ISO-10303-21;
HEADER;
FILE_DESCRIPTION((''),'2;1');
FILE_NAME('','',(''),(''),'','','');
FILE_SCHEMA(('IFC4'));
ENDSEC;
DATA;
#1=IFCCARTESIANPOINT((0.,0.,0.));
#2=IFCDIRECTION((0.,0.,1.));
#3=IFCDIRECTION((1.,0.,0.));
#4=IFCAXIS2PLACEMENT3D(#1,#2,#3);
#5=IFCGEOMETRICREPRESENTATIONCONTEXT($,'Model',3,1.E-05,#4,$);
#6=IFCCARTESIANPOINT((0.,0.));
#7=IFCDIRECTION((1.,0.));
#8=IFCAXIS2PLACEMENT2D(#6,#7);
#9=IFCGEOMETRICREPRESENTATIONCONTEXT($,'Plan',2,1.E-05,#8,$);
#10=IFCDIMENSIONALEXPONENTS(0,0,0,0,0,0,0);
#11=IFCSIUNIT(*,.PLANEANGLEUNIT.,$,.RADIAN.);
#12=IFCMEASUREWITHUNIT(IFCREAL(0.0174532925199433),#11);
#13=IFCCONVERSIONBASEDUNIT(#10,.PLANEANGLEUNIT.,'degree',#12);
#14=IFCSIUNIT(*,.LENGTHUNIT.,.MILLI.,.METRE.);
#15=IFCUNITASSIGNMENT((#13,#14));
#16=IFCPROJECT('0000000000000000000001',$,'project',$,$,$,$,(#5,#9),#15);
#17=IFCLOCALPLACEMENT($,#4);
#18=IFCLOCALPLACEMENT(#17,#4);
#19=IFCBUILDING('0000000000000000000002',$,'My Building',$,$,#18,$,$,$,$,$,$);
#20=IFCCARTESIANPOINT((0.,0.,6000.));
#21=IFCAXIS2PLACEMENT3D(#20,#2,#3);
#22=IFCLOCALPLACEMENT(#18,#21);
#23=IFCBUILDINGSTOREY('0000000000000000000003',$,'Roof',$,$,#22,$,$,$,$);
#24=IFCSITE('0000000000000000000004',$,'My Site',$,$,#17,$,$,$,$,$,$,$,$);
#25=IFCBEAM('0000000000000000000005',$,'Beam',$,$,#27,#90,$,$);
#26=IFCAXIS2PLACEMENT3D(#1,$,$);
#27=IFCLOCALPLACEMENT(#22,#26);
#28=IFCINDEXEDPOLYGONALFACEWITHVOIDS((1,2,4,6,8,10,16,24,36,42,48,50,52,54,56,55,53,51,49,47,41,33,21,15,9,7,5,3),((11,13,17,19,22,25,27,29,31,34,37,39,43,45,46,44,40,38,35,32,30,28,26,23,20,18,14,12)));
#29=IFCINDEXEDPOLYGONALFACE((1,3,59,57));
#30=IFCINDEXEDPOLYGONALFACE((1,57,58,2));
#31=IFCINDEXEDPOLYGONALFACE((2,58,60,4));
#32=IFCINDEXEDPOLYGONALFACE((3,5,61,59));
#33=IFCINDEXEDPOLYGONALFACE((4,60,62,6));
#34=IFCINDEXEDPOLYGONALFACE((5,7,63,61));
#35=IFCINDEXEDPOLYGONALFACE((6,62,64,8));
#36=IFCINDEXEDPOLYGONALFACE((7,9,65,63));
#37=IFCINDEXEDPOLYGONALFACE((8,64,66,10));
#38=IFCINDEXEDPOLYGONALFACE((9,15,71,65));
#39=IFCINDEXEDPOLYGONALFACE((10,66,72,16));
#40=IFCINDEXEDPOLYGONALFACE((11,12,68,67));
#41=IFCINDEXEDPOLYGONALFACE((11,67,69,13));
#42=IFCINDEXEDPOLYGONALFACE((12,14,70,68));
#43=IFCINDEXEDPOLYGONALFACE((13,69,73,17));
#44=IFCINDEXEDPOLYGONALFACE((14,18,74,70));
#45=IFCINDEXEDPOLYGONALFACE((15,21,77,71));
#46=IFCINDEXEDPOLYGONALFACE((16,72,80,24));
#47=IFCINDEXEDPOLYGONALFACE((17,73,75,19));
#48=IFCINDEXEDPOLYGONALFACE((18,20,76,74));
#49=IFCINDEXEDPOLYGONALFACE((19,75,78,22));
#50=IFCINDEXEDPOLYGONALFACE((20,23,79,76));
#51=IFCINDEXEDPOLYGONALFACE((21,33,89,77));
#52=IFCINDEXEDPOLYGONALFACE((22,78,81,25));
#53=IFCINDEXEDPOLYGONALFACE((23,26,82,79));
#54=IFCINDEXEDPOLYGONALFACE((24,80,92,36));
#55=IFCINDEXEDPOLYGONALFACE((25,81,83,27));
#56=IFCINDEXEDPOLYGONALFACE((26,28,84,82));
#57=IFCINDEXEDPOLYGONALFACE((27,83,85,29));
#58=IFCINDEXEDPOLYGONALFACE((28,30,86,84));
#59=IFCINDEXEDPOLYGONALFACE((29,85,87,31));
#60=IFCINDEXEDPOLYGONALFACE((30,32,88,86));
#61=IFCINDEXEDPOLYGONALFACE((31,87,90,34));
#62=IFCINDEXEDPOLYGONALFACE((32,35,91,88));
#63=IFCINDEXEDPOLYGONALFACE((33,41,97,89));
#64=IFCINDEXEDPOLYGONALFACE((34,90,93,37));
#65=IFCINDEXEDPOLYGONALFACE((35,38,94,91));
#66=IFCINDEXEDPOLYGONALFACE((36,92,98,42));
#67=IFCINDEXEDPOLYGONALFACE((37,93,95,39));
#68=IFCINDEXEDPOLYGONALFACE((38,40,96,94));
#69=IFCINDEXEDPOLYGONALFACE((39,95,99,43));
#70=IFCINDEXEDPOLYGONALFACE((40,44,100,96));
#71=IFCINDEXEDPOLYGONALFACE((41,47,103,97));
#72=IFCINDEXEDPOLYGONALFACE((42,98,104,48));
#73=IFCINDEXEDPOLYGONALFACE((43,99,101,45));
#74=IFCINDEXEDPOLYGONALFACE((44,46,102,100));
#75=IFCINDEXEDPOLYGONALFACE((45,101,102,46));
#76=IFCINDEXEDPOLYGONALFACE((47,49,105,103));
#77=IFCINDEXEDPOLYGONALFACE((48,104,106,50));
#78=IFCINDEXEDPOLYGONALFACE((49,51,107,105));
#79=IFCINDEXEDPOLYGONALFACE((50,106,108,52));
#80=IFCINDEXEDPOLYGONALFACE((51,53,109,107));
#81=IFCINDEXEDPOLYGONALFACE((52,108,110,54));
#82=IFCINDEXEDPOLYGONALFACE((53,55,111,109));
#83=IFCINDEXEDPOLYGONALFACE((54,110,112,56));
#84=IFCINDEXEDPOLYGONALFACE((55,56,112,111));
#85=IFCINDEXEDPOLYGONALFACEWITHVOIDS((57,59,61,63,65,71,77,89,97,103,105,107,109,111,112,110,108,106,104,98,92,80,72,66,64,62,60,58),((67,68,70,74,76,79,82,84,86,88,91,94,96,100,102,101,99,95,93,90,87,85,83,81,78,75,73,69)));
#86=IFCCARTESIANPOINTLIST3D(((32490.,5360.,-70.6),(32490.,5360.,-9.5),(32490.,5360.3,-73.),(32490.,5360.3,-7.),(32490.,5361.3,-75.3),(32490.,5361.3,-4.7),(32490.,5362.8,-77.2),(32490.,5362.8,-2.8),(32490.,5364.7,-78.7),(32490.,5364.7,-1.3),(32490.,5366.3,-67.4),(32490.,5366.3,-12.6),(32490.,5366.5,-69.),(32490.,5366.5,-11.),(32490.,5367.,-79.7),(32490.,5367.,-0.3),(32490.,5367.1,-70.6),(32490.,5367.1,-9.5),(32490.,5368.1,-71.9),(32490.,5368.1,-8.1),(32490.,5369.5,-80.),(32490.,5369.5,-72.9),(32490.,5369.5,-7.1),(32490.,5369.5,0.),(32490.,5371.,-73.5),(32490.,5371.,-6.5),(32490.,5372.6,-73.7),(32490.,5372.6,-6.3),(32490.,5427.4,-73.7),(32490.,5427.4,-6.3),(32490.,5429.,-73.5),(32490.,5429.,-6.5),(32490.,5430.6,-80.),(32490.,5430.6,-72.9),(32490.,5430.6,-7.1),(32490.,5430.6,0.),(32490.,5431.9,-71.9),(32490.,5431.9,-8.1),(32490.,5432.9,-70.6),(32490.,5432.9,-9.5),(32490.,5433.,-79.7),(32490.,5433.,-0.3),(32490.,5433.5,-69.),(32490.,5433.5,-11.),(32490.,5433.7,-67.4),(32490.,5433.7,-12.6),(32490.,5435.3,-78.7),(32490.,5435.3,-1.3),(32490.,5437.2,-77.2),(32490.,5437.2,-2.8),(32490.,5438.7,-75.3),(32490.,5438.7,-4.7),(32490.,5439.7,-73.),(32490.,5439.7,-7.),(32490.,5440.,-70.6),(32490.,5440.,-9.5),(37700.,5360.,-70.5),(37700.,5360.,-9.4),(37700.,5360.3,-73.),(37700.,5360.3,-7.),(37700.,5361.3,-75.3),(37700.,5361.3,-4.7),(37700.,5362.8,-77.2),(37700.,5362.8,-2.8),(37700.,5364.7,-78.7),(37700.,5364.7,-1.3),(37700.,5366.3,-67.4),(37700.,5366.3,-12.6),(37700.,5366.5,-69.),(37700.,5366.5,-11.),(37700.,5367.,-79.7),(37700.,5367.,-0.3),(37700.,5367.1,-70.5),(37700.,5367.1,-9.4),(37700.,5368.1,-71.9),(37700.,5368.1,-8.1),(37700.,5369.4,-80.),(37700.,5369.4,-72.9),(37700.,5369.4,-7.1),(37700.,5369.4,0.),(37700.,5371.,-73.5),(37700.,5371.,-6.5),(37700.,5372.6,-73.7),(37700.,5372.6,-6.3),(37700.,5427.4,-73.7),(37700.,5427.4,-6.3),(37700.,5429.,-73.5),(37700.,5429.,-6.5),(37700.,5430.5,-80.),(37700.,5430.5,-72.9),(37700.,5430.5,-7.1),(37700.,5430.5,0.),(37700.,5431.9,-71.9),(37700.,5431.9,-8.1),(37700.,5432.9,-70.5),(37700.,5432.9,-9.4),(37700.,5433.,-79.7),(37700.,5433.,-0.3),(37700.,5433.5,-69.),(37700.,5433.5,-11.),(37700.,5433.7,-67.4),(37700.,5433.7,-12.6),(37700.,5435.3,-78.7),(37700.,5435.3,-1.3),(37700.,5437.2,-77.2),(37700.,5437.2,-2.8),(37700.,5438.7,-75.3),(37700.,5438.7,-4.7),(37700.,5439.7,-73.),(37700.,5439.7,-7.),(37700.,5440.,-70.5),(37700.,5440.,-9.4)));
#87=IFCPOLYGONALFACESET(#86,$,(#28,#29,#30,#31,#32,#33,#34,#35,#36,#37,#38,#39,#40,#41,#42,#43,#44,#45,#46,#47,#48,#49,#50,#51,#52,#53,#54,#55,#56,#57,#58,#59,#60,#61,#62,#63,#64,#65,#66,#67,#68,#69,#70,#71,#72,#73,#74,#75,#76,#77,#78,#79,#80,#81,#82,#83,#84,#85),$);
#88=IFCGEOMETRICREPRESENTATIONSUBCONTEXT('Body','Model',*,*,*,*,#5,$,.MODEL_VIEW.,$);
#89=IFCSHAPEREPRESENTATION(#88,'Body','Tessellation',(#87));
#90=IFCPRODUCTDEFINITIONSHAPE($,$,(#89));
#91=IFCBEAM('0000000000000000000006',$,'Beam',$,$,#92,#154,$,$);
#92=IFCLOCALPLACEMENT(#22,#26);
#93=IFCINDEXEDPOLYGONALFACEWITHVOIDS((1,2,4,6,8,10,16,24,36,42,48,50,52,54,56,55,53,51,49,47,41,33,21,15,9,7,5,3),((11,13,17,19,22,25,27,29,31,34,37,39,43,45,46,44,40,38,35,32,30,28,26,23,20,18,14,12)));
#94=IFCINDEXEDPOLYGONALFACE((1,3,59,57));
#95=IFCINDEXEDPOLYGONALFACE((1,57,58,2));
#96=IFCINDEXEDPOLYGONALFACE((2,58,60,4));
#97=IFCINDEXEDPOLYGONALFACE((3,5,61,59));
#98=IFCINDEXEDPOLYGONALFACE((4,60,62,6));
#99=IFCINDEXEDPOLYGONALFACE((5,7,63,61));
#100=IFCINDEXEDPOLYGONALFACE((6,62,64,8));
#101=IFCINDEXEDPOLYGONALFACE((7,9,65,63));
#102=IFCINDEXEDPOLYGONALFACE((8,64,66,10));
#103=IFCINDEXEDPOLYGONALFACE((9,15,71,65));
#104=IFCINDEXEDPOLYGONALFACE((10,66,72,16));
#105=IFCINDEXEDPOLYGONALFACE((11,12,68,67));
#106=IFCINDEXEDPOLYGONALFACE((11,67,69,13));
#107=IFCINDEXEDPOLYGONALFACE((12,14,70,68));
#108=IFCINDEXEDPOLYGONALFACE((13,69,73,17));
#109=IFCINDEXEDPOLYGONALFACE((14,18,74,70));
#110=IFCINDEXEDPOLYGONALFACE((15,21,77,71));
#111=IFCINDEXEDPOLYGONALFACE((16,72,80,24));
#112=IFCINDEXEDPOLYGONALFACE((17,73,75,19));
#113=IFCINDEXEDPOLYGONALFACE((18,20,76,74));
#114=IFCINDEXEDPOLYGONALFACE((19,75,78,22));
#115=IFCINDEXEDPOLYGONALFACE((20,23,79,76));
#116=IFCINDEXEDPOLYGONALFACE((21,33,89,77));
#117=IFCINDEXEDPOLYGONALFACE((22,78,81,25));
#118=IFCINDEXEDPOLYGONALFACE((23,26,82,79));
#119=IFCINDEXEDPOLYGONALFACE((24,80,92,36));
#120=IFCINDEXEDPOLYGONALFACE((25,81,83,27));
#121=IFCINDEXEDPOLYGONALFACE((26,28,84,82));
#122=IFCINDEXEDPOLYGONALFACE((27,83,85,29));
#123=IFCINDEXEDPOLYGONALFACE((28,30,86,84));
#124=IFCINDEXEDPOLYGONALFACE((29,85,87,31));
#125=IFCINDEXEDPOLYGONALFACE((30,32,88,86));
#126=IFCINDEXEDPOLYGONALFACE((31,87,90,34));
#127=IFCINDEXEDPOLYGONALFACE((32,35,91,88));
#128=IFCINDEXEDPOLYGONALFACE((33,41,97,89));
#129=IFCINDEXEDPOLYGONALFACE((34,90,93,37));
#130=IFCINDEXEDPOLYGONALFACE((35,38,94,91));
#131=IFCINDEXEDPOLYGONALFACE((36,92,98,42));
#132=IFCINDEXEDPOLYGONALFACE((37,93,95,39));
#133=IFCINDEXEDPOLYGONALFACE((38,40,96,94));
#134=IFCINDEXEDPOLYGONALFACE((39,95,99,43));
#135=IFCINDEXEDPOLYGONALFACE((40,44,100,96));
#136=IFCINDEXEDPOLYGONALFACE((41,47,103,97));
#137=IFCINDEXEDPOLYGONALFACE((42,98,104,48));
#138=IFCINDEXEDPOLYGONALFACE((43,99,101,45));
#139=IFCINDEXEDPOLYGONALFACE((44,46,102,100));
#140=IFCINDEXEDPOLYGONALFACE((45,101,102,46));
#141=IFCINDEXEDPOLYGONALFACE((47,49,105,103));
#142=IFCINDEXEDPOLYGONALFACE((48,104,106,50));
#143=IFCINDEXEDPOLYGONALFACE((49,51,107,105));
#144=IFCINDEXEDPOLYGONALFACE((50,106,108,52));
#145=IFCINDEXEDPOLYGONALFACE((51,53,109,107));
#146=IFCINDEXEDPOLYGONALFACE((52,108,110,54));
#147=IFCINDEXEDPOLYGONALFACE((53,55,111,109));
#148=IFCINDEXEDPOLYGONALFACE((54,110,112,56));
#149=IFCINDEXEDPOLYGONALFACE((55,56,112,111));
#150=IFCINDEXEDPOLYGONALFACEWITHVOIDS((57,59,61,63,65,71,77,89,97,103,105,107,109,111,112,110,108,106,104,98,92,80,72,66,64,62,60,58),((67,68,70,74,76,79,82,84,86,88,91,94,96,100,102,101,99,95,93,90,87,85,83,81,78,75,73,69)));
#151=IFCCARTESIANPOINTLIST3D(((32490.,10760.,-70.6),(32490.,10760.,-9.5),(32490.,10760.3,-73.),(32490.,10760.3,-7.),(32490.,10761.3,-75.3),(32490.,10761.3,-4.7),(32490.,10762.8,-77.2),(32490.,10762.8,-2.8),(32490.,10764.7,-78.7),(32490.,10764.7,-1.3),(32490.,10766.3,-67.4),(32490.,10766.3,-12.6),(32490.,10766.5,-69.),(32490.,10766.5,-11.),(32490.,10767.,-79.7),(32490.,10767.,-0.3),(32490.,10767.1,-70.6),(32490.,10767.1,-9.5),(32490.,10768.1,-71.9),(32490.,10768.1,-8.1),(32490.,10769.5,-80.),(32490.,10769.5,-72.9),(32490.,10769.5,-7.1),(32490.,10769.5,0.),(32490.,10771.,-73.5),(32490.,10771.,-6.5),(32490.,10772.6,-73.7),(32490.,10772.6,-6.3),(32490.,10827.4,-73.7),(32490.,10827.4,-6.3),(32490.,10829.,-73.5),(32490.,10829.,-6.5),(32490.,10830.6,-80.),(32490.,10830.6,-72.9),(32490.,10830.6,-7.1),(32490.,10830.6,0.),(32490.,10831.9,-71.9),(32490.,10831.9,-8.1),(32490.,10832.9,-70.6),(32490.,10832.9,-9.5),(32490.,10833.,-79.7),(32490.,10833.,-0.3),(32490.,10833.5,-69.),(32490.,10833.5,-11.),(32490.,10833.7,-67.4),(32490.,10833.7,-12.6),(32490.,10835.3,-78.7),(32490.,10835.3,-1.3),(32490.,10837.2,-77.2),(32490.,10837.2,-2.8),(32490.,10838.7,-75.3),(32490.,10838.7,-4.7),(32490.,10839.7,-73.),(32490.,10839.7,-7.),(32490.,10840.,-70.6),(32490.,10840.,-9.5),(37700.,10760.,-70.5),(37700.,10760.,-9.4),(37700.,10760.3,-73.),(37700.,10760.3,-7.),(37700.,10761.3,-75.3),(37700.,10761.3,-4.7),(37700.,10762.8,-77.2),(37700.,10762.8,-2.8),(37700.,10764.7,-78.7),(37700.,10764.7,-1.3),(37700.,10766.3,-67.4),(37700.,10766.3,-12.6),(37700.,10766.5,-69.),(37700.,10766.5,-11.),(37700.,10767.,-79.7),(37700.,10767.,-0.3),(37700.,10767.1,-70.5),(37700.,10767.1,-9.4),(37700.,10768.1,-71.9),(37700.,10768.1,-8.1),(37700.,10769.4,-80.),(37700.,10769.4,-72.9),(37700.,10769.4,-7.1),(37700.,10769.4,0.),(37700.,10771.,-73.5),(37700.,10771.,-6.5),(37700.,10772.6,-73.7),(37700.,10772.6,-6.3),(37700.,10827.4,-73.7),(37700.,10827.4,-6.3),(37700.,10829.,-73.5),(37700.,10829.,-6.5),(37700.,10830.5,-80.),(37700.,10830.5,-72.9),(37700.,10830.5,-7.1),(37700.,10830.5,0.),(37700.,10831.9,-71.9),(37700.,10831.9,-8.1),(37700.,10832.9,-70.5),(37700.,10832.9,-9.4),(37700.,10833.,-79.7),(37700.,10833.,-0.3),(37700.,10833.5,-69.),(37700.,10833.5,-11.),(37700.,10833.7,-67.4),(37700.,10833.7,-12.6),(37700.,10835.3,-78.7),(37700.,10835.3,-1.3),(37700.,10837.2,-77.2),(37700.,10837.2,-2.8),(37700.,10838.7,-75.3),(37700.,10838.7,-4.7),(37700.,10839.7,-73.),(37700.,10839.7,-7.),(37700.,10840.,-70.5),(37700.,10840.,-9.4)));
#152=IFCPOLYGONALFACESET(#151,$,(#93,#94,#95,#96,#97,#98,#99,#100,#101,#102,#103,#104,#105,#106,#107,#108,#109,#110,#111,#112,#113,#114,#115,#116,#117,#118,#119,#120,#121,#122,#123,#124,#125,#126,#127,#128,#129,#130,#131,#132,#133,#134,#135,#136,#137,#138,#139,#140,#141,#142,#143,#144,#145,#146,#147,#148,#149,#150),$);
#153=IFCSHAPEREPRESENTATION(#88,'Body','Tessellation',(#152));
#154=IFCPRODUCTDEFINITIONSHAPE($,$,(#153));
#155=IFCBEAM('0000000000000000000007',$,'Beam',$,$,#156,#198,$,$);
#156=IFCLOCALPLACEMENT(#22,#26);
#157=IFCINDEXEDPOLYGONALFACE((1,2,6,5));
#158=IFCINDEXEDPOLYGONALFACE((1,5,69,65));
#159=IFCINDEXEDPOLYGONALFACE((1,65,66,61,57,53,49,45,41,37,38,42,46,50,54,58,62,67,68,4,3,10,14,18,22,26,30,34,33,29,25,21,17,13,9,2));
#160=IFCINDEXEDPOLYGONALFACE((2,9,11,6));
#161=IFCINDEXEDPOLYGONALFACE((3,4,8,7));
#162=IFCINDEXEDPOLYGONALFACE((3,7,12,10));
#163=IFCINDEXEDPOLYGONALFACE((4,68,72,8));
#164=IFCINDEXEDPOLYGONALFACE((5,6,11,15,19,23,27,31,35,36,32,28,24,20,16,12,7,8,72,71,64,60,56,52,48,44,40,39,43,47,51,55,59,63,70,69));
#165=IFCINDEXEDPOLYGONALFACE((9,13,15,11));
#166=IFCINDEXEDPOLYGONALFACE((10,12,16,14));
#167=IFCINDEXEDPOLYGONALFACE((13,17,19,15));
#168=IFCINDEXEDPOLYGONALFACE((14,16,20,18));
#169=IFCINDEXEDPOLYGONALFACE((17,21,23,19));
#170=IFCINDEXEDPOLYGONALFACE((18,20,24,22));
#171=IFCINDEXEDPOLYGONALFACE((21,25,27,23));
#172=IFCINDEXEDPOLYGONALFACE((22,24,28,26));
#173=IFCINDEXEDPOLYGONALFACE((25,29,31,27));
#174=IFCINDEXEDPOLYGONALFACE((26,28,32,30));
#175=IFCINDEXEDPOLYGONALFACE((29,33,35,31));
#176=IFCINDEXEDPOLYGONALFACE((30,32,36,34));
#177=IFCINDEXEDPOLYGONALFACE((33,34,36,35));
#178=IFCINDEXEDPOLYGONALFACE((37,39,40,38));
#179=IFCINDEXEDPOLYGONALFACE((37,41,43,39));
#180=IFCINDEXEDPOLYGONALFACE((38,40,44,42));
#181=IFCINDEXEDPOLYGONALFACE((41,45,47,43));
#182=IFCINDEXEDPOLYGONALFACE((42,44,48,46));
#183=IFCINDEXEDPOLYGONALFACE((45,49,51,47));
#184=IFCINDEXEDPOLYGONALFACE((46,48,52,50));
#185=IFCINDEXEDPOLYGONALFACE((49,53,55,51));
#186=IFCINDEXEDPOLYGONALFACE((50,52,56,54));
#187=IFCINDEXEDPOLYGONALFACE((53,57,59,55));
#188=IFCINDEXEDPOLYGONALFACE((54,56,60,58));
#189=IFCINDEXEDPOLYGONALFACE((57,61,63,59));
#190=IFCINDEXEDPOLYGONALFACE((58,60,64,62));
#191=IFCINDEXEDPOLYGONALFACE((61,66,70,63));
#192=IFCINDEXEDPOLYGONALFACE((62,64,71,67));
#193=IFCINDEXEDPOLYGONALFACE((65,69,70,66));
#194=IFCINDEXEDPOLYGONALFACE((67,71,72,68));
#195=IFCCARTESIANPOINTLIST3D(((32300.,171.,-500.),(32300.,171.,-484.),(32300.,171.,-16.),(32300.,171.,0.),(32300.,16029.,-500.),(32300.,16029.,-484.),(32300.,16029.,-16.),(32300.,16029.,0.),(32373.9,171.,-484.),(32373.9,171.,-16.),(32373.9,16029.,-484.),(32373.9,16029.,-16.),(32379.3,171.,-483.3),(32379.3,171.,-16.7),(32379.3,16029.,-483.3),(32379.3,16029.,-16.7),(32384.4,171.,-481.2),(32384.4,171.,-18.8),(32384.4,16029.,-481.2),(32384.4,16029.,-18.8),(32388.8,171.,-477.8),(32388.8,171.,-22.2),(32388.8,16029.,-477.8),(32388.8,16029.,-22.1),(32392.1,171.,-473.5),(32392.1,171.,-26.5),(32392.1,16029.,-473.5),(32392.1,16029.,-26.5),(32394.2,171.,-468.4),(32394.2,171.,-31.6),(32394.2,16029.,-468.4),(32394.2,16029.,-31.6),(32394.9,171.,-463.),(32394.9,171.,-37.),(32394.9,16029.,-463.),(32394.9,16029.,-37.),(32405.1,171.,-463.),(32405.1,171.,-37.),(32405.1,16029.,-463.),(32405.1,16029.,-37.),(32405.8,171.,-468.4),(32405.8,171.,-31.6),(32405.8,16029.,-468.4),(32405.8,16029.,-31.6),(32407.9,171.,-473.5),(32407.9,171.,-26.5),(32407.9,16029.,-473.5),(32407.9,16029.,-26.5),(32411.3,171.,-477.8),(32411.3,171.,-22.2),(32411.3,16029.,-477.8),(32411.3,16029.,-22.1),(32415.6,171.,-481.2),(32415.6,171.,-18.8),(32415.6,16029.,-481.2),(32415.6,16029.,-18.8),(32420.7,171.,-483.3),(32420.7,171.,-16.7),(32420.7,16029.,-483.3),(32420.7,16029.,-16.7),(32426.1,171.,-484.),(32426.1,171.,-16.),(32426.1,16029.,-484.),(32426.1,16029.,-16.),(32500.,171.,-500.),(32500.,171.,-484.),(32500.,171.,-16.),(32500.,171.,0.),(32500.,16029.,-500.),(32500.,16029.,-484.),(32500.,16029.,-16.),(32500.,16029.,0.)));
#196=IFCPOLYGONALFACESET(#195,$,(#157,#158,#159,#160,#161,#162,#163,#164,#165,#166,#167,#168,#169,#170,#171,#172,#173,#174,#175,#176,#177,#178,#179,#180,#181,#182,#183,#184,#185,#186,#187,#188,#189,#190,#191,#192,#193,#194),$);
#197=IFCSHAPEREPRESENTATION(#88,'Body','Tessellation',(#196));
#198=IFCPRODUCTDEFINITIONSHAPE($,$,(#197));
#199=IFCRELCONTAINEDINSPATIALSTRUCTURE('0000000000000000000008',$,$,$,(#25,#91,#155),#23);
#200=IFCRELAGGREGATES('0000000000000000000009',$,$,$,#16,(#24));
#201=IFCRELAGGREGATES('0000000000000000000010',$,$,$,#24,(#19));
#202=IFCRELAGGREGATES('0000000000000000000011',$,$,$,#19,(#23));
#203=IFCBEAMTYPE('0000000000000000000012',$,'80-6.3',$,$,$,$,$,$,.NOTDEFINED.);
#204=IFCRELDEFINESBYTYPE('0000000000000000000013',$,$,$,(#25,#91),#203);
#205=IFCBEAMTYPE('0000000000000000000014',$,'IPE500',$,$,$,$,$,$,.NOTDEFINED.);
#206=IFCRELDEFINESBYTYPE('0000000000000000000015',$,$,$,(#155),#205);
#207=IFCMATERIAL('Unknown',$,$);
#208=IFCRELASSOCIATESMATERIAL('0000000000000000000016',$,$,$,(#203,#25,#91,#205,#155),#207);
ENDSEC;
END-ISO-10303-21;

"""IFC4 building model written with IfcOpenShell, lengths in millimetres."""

from ifc_helpers import new_model, entity, si_unit, converted_unit, frame, origin_with_axes, origin_2d_with_axis, place, context, subcontext, project, spatial, hollow_rectangle, i_section, extrude, material, material_profile, profile_set, profile_usage, type_object, element, save


model = new_model("IFC4")

# Units and contexts
model_context = context("Model", 3, precision=1e-05, world=origin_with_axes())
plan_context = context("Plan", 2, precision=1e-05, world=origin_2d_with_axis())
body_context = subcontext(model_context, "Body", "Model", "MODEL_VIEW")
ifc_project = project(units=[converted_unit("PLANEANGLEUNIT", "degree", entity("IfcReal", 0.0174532925199433), si_unit("PLANEANGLEUNIT", "RADIAN"), dimensions=[0, 0, 0, 0, 0, 0, 0]), si_unit("LENGTHUNIT", "METRE", prefix="MILLI")], contexts=[model_context, plan_context])

# Site, building, storey
site_placement = place(None, origin_with_axes())
site = spatial("IfcSite", under=ifc_project, at=site_placement, Name="My Site")
building_placement = place(site_placement, origin_with_axes())
building = spatial("IfcBuilding", under=site, at=building_placement, Name="My Building")
storey_placement = place(building_placement, frame((0.0, 0.0, 6000.0), z_axis=(0.0, 0.0, 1.0), x_axis=(1.0, 0.0, 0.0)))
storey = spatial("IfcBuildingStorey", under=building, at=storey_placement, Name="Roof")

# Beams
ifc_material = material(Name="Unknown")
ifc_material_profile_1 = material_profile(ifc_material, hollow_rectangle(XDim=80.0, YDim=80.0, WallThickness=6.3, InnerFilletRadius=6.3, OuterFilletRadius=9.4))
ifc_profile_set_1 = profile_set([ifc_material_profile_1])
beam_type_1 = type_object("IfcBeamType", Name="80-6.3", PredefinedType="NOTDEFINED", material=ifc_profile_set_1)
ifc_profile_usage_1 = profile_usage(ifc_profile_set_1, cardinal=8)
beam_1_placement = place(storey_placement, frame((32490.0, 5400.0, 0.0), z_axis=(1.0, 0.0, 0.0), x_axis=(0.0, 1.0, 0.0)))
element("IfcBeam", 1, at=beam_1_placement, inside=storey, type_object=beam_type_1, material=ifc_profile_usage_1, Name="Beam", context=body_context, shape_type="SweptSolid", body=[
    extrude(hollow_rectangle(XDim=80.0, YDim=80.0, WallThickness=6.3, InnerFilletRadius=6.3, OuterFilletRadius=9.4), frame((0.0, -40.0, 0.0), z_axis=(0.0, 0.0, 1.0), x_axis=(1.0, 0.0, 0.0)), (0.0, 0.0, 1.0), 5210.0),
])
ifc_profile_usage_2 = profile_usage(ifc_profile_set_1, cardinal=8)
beam_2_placement = place(storey_placement, frame((32490.0, 10800.0, 0.0), z_axis=(1.0, 0.0, 0.0), x_axis=(0.0, 1.0, 0.0)))
element("IfcBeam", 2, at=beam_2_placement, inside=storey, type_object=beam_type_1, material=ifc_profile_usage_2, Name="Beam", context=body_context, shape_type="SweptSolid", body=[
    extrude(hollow_rectangle(XDim=80.0, YDim=80.0, WallThickness=6.3, InnerFilletRadius=6.3, OuterFilletRadius=9.4), frame((0.0, -40.0, 0.0), z_axis=(0.0, 0.0, 1.0), x_axis=(1.0, 0.0, 0.0)), (0.0, 0.0, 1.0), 5210.0),
])
ifc_material_profile_2 = material_profile(ifc_material, i_section(OverallWidth=200.0, OverallDepth=500.0, WebThickness=10.2, FlangeThickness=16.0, FilletRadius=21.0))
ifc_profile_set_2 = profile_set([ifc_material_profile_2])
ifc_profile_usage_3 = profile_usage(ifc_profile_set_2, cardinal=8)
beam_type_2 = type_object("IfcBeamType", Name="IPE500", PredefinedType="NOTDEFINED", material=ifc_profile_set_2)
beam_3_placement = place(storey_placement, frame((32400.0, 171.0, 0.0), z_axis=(0.0, 1.0, 0.0), x_axis=(-1.0, 0.0, 0.0)))
element("IfcBeam", 3, at=beam_3_placement, inside=storey, type_object=beam_type_2, material=ifc_profile_usage_3, Name="Beam", context=body_context, shape_type="SweptSolid", body=[
    extrude(i_section(OverallWidth=200.0, OverallDepth=500.0, WebThickness=10.2, FlangeThickness=16.0, FilletRadius=21.0), frame((0.0, -250.0, 0.0), z_axis=(0.0, 0.0, 1.0), x_axis=(1.0, 0.0, 0.0)), (0.0, 0.0, 1.0), 15858.0),
])

save(model, "model.ifc")
